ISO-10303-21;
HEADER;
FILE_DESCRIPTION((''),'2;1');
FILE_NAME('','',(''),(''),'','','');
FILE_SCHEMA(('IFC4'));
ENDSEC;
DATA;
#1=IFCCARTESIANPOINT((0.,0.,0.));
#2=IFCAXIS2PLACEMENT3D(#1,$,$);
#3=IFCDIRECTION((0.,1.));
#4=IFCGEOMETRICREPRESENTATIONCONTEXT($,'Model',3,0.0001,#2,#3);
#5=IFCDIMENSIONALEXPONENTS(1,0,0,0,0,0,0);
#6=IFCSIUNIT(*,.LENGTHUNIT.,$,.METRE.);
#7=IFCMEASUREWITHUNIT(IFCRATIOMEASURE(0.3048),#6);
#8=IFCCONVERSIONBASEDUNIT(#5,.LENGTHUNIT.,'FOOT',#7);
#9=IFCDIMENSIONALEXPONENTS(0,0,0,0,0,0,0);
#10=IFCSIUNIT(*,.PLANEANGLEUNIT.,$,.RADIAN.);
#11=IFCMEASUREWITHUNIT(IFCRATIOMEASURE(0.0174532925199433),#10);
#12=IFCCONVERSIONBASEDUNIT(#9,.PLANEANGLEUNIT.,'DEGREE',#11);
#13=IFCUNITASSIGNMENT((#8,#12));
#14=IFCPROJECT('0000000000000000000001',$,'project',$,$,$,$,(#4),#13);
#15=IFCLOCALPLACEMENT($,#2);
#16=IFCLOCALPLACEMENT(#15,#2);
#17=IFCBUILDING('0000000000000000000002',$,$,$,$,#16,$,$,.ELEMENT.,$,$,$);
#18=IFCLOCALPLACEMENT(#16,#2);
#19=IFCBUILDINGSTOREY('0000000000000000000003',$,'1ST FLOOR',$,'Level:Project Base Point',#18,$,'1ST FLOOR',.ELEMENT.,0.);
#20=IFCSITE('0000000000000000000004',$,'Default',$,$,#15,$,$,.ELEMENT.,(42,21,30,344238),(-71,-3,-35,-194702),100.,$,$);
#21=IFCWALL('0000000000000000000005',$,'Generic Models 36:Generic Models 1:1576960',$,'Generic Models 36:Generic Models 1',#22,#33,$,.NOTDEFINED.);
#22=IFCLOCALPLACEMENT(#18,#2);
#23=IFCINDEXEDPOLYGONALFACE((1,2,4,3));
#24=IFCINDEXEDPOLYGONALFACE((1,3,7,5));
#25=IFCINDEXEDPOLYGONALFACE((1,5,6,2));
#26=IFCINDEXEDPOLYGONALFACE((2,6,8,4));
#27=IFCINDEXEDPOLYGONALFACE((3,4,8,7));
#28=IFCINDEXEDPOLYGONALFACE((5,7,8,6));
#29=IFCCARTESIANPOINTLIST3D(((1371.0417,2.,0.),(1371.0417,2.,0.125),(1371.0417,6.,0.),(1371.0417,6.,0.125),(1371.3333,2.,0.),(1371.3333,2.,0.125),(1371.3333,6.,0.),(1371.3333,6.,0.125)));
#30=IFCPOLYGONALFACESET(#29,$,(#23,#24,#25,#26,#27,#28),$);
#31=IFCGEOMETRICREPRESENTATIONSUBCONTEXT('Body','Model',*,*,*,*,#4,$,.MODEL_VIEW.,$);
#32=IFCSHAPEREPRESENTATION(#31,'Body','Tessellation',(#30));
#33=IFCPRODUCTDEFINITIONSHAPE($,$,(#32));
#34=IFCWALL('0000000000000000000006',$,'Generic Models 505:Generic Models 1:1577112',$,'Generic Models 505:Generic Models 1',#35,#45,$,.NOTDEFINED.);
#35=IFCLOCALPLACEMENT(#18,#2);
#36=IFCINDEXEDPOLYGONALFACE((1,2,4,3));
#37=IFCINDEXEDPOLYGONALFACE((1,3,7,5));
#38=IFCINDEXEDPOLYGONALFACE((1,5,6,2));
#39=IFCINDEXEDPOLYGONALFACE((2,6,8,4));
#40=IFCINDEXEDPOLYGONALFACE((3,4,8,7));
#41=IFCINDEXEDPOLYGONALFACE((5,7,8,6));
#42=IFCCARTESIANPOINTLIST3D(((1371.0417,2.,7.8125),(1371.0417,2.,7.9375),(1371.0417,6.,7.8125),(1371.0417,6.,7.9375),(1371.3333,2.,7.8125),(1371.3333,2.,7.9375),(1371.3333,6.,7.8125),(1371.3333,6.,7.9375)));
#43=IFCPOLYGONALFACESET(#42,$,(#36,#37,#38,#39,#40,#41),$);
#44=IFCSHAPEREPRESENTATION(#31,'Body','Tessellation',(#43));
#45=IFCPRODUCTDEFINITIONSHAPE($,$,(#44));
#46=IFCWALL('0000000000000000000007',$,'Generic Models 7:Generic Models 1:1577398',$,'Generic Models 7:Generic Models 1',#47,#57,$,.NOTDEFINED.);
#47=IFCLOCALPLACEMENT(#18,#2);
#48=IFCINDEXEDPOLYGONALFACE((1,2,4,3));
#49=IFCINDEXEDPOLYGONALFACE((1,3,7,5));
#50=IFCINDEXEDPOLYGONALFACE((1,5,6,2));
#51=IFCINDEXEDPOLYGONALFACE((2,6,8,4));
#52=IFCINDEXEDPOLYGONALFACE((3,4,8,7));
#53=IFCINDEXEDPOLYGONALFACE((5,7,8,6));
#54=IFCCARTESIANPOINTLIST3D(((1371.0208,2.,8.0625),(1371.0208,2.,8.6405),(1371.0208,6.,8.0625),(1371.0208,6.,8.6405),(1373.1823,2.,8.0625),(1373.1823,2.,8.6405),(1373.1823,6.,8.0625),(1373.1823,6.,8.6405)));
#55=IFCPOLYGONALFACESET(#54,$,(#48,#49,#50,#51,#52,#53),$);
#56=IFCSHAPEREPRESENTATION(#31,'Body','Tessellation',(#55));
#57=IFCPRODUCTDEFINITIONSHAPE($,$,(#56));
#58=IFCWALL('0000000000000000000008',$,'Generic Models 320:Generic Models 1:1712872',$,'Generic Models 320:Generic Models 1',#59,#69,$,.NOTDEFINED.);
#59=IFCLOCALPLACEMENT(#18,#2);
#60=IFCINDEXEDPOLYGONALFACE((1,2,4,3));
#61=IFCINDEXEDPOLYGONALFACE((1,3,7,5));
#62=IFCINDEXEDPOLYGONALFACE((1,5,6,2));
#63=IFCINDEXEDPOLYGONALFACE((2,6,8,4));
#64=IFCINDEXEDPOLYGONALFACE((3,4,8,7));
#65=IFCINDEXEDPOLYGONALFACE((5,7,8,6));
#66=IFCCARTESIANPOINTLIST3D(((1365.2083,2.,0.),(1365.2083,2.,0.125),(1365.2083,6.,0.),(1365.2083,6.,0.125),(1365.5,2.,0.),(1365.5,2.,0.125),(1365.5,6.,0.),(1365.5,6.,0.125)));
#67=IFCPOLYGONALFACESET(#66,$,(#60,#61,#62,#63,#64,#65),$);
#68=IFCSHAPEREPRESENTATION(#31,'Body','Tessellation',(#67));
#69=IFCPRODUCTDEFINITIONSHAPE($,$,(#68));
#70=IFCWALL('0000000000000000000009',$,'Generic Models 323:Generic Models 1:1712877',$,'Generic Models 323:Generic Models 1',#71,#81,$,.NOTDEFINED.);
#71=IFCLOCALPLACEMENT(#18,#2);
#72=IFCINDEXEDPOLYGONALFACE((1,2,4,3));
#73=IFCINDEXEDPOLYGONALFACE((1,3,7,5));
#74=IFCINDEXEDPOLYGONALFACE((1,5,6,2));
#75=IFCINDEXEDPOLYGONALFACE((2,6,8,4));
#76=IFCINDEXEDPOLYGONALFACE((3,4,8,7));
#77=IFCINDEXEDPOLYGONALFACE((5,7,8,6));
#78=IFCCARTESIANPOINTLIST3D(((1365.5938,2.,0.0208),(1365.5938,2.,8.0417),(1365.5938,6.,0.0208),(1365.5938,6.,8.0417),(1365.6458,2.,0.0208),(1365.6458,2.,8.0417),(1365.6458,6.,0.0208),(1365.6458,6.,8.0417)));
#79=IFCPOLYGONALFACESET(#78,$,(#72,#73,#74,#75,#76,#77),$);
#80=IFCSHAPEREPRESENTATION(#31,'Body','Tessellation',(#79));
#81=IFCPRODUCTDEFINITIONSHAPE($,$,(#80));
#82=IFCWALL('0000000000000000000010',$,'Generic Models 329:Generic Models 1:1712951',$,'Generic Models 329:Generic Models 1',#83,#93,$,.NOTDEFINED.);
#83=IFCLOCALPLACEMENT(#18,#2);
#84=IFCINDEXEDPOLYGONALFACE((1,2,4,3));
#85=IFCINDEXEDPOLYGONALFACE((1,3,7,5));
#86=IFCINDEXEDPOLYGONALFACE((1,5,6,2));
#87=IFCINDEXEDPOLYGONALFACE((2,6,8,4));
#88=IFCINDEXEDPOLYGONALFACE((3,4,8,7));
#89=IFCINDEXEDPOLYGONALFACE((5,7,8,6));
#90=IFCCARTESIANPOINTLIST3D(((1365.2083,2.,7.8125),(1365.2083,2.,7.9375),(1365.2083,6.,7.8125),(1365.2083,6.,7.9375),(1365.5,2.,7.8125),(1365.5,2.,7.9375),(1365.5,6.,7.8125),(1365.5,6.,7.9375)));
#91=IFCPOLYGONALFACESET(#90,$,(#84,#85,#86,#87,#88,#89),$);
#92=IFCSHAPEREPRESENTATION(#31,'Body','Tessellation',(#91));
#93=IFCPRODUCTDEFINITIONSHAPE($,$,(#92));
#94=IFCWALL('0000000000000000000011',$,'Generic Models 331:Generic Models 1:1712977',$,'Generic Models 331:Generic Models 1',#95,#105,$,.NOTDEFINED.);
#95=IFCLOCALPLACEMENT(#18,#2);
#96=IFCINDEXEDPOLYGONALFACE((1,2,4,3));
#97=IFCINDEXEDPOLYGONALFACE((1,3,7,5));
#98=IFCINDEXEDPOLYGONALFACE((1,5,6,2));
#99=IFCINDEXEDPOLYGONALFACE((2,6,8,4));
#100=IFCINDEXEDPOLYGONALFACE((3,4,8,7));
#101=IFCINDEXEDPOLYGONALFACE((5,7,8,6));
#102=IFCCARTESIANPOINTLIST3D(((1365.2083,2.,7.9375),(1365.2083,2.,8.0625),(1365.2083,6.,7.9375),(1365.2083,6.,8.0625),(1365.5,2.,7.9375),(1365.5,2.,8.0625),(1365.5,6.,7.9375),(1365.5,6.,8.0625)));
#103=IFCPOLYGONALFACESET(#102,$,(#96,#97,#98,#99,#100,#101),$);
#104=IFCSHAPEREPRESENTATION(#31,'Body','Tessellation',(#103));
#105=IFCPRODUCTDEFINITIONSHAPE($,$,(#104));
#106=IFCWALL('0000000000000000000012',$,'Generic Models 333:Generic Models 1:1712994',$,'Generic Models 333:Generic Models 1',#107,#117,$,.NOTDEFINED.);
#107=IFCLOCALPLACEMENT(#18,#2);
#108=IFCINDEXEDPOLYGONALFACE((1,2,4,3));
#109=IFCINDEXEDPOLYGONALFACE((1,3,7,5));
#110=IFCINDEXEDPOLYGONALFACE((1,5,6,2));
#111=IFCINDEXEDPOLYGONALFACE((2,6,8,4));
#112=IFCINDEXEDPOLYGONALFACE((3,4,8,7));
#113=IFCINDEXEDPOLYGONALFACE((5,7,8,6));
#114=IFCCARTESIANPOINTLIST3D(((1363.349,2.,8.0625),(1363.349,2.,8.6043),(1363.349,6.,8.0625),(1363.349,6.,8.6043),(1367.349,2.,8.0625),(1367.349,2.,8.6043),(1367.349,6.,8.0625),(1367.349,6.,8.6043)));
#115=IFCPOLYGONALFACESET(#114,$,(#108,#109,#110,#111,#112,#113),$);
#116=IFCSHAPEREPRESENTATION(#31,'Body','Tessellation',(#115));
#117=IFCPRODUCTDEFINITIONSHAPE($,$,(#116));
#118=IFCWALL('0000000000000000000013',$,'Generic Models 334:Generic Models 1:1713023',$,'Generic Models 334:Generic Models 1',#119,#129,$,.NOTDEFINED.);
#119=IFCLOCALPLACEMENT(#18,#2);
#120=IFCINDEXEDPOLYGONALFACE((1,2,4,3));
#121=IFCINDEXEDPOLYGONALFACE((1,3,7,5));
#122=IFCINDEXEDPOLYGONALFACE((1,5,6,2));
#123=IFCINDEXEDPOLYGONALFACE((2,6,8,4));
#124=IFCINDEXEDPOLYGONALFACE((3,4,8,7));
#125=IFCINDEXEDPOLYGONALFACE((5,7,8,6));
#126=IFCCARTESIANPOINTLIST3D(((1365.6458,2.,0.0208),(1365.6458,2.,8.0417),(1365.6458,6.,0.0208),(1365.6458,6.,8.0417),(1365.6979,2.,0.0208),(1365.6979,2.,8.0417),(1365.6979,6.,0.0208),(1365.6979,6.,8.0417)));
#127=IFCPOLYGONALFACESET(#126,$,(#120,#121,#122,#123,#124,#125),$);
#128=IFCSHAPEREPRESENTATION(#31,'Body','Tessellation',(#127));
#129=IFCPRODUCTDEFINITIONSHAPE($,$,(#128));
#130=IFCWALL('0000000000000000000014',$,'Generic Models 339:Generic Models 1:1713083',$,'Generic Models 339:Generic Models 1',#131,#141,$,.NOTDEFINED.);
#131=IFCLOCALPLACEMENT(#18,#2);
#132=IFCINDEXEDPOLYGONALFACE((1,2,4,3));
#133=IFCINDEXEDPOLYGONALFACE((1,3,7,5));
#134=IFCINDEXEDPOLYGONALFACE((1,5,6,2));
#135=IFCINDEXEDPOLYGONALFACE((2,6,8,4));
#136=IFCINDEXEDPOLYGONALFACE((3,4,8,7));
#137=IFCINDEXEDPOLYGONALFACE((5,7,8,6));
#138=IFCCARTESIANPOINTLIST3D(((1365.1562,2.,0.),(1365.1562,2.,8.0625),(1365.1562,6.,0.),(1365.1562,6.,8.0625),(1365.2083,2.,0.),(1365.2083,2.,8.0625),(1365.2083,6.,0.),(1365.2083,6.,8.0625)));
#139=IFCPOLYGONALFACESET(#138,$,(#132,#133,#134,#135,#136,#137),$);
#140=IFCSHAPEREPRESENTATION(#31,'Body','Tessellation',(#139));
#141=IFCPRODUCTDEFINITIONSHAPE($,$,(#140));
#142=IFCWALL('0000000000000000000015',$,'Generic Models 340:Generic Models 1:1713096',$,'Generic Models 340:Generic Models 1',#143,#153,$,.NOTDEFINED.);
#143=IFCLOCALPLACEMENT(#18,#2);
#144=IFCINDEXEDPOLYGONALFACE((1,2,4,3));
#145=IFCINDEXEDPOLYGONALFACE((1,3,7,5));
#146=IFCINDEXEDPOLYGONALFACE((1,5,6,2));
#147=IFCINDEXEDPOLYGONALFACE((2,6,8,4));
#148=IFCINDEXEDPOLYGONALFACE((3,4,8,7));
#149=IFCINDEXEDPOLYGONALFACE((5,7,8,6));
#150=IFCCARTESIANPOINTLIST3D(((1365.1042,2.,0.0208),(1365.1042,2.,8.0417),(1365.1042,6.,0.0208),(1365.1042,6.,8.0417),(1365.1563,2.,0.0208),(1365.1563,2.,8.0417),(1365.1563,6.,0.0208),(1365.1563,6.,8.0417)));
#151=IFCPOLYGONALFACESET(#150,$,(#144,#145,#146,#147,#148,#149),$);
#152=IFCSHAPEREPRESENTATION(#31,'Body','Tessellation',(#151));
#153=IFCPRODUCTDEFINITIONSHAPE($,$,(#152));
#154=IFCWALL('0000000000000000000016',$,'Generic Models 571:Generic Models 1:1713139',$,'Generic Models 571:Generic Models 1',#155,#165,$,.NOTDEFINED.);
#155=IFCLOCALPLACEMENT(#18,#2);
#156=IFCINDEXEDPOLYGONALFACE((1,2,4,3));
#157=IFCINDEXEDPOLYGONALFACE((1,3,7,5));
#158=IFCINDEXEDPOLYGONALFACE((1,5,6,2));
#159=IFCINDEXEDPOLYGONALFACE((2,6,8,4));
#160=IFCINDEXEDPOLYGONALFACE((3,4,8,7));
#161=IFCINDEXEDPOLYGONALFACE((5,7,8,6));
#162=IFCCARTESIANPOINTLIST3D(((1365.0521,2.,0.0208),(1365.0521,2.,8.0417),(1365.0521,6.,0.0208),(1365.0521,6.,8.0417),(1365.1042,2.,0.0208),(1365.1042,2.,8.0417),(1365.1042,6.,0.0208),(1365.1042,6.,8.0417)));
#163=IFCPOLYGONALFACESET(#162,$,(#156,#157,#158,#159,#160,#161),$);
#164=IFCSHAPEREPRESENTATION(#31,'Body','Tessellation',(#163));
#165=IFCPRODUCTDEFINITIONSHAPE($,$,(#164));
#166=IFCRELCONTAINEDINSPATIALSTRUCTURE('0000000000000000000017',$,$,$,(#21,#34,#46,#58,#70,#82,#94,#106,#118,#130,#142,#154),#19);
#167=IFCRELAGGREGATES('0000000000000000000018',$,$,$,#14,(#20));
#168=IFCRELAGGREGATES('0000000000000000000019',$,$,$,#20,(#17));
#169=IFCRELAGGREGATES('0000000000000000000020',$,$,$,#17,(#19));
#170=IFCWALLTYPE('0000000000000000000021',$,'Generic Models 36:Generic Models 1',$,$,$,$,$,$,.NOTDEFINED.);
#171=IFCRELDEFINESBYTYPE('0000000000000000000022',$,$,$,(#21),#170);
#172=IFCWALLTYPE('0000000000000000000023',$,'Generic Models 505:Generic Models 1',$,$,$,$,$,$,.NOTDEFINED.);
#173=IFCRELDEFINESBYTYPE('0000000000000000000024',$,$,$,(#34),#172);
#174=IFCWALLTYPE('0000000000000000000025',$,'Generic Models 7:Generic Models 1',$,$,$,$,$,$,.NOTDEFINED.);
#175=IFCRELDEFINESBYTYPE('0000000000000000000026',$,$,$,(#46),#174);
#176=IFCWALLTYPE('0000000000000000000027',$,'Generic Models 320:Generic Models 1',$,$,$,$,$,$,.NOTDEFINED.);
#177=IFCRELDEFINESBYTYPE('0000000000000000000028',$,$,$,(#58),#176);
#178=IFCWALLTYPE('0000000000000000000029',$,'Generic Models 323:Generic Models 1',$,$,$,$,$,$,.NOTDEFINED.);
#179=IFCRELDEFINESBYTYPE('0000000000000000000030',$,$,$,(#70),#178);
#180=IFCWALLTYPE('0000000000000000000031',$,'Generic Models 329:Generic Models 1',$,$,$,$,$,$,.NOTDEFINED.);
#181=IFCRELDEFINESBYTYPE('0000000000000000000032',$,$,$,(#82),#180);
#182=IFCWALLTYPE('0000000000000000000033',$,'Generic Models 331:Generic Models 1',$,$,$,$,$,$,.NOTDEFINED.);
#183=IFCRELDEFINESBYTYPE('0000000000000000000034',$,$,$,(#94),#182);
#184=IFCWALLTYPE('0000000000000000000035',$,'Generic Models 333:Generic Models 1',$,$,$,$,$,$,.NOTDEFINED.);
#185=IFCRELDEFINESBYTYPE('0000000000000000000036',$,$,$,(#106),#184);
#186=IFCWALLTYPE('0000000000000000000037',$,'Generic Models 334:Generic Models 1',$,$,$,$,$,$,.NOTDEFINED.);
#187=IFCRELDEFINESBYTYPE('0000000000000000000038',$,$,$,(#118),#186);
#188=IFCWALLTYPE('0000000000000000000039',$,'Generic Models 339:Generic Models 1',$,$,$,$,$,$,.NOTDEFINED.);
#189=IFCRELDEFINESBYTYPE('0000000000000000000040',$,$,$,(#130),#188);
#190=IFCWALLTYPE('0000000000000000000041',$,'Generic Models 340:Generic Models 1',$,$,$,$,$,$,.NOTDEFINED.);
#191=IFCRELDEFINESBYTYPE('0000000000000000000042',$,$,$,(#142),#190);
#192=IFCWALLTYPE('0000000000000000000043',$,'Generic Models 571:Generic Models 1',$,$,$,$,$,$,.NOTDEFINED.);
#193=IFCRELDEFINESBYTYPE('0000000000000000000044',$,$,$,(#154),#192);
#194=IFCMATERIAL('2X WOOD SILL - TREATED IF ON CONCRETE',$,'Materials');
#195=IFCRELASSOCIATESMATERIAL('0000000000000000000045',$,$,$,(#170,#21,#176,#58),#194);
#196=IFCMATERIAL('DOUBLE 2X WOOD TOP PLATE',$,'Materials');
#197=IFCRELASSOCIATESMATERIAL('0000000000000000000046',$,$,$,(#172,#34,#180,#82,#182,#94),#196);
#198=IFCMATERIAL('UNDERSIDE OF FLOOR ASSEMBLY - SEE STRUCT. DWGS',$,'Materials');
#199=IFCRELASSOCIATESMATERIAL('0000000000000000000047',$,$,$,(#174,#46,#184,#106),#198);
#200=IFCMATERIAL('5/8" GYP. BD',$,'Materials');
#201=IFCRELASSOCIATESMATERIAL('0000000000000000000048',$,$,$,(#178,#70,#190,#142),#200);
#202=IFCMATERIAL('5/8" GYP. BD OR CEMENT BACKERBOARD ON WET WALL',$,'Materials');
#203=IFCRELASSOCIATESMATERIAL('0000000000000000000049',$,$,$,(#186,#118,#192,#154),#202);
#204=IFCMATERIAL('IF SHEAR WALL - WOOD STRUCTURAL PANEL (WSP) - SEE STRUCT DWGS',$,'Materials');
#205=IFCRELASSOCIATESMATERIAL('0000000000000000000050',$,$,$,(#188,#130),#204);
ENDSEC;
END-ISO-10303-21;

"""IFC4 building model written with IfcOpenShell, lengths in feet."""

from ifc_helpers import new_model, entity, si_unit, converted_unit, direction, frame, frame_2d, origin, origin_2d_with_axis, place, context, subcontext, project, spatial, rectangle, extrude, material, type_object, element, save


model = new_model("IFC4")

# Units and contexts
model_context = context("Model", 3, precision=0.0001, world=origin(), true_north=direction((0.0, 1.0)))
body_context = subcontext(model_context, "Body", "Model", "MODEL_VIEW")
ifc_project = project(units=[converted_unit("LENGTHUNIT", "FOOT", entity("IfcRatioMeasure", 0.3048), si_unit("LENGTHUNIT", "METRE"), dimensions=[1, 0, 0, 0, 0, 0, 0]), converted_unit("PLANEANGLEUNIT", "DEGREE", entity("IfcRatioMeasure", 0.0174532925199433), si_unit("PLANEANGLEUNIT", "RADIAN"), dimensions=[0, 0, 0, 0, 0, 0, 0])], contexts=[model_context])

# Site, building, storey
site_placement = place(None, origin())
site = spatial("IfcSite", under=ifc_project, at=site_placement, Name="Default", CompositionType="ELEMENT", RefLatitude=(42, 21, 30, 344238), RefLongitude=(-71, -3, -35, -194702), RefElevation=100.0)
building_placement = place(site_placement, origin())
building = spatial("IfcBuilding", under=site, at=building_placement, CompositionType="ELEMENT")
storey_placement = place(building_placement, origin())
storey = spatial("IfcBuildingStorey", under=building, at=storey_placement, Name="1ST FLOOR", ObjectType="Level:Project Base Point", LongName="1ST FLOOR", CompositionType="ELEMENT", Elevation=0.0)

# Walls
ifc_material_1 = material(Name="2X WOOD SILL - TREATED IF ON CONCRETE", Category="Materials")
wall_type_1 = type_object("IfcWallType", Name="Generic Models 36:Generic Models 1", PredefinedType="NOTDEFINED", material=ifc_material_1)
wall_1_placement = place(storey_placement, frame((1371.0417, 2.0, 0.0), z_axis=(0.0, 0.0, 1.0), x_axis=(0.0, 1.0, 0.0)))
element("IfcWall", 1, at=wall_1_placement, inside=storey, type_object=wall_type_1, material=ifc_material_1, Name="Generic Models 36:Generic Models 1:1576960", ObjectType="Generic Models 36:Generic Models 1", PredefinedType="NOTDEFINED", context=body_context, shape_type="SweptSolid", body=[
    extrude(rectangle(XDim=4.0, YDim=0.2917, at=frame_2d((0.0, 0.0), x_axis=(1.0, 0.0))), frame((2.0, -0.1458, 0.0)), (0.0, 0.0, 1.0), 0.125),
])
ifc_material_2 = material(Name="DOUBLE 2X WOOD TOP PLATE", Category="Materials")
wall_type_2 = type_object("IfcWallType", Name="Generic Models 505:Generic Models 1", PredefinedType="NOTDEFINED", material=ifc_material_2)
wall_2_placement = place(storey_placement, frame((1371.0417, 2.0, 7.8125), z_axis=(0.0, 0.0, 1.0), x_axis=(0.0, 1.0, 0.0)))
element("IfcWall", 2, at=wall_2_placement, inside=storey, type_object=wall_type_2, material=ifc_material_2, Name="Generic Models 505:Generic Models 1:1577112", ObjectType="Generic Models 505:Generic Models 1", PredefinedType="NOTDEFINED", context=body_context, shape_type="SweptSolid", body=[
    extrude(rectangle(XDim=4.0, YDim=0.2917, at=frame_2d((0.0, 0.0), x_axis=(1.0, 0.0))), frame((2.0, -0.1458, 0.0)), (0.0, 0.0, 1.0), 0.125),
])
ifc_material_3 = material(Name="UNDERSIDE OF FLOOR ASSEMBLY - SEE STRUCT. DWGS", Category="Materials")
wall_type_3 = type_object("IfcWallType", Name="Generic Models 7:Generic Models 1", PredefinedType="NOTDEFINED", material=ifc_material_3)
wall_3_placement = place(storey_placement, frame((1371.0208, 2.0, 8.0625), z_axis=(0.0, 0.0, 1.0), x_axis=(0.0, 1.0, 0.0)))
element("IfcWall", 3, at=wall_3_placement, inside=storey, type_object=wall_type_3, material=ifc_material_3, Name="Generic Models 7:Generic Models 1:1577398", ObjectType="Generic Models 7:Generic Models 1", PredefinedType="NOTDEFINED", context=body_context, shape_type="SweptSolid", body=[
    extrude(rectangle(XDim=4.0, YDim=2.1615, at=frame_2d((0.0, 0.0), x_axis=(1.0, 0.0))), frame((2.0, -1.0807, 0.0)), (0.0, 0.0, 1.0), 0.578),
])
wall_type_4 = type_object("IfcWallType", Name="Generic Models 320:Generic Models 1", PredefinedType="NOTDEFINED", material=ifc_material_1)
wall_4_placement = place(storey_placement, frame((1365.2083, 2.0, 0.0), z_axis=(0.0, 0.0, 1.0), x_axis=(0.0, 1.0, 0.0)))
element("IfcWall", 4, at=wall_4_placement, inside=storey, type_object=wall_type_4, material=ifc_material_1, Name="Generic Models 320:Generic Models 1:1712872", ObjectType="Generic Models 320:Generic Models 1", PredefinedType="NOTDEFINED", context=body_context, shape_type="SweptSolid", body=[
    extrude(rectangle(XDim=4.0, YDim=0.2917, at=frame_2d((0.0, 0.0), x_axis=(1.0, 0.0))), frame((2.0, -0.1458, 0.0)), (0.0, 0.0, 1.0), 0.125),
])
ifc_material_4 = material(Name="5/8\" GYP. BD", Category="Materials")
wall_type_5 = type_object("IfcWallType", Name="Generic Models 323:Generic Models 1", PredefinedType="NOTDEFINED", material=ifc_material_4)
wall_5_placement = place(storey_placement, frame((1365.5938, 2.0, 0.0208), z_axis=(0.0, 0.0, 1.0), x_axis=(0.0, 1.0, 0.0)))
element("IfcWall", 5, at=wall_5_placement, inside=storey, type_object=wall_type_5, material=ifc_material_4, Name="Generic Models 323:Generic Models 1:1712877", ObjectType="Generic Models 323:Generic Models 1", PredefinedType="NOTDEFINED", context=body_context, shape_type="SweptSolid", body=[
    extrude(rectangle(XDim=4.0, YDim=0.0521, at=origin_2d_with_axis()), frame((2.0, -0.026, 0.0)), (0.0, 0.0, 1.0), 8.0208),
])
wall_type_6 = type_object("IfcWallType", Name="Generic Models 329:Generic Models 1", PredefinedType="NOTDEFINED", material=ifc_material_2)
wall_6_placement = place(storey_placement, frame((1365.2083, 2.0, 7.8125), z_axis=(0.0, 0.0, 1.0), x_axis=(0.0, 1.0, 0.0)))
element("IfcWall", 6, at=wall_6_placement, inside=storey, type_object=wall_type_6, material=ifc_material_2, Name="Generic Models 329:Generic Models 1:1712951", ObjectType="Generic Models 329:Generic Models 1", PredefinedType="NOTDEFINED", context=body_context, shape_type="SweptSolid", body=[
    extrude(rectangle(XDim=4.0, YDim=0.2917, at=frame_2d((0.0, 0.0), x_axis=(1.0, 0.0))), frame((2.0, -0.1458, 0.0)), (0.0, 0.0, 1.0), 0.125),
])
wall_type_7 = type_object("IfcWallType", Name="Generic Models 331:Generic Models 1", PredefinedType="NOTDEFINED", material=ifc_material_2)
wall_7_placement = place(storey_placement, frame((1365.2083, 2.0, 7.9375), z_axis=(0.0, 0.0, 1.0), x_axis=(0.0, 1.0, 0.0)))
element("IfcWall", 7, at=wall_7_placement, inside=storey, type_object=wall_type_7, material=ifc_material_2, Name="Generic Models 331:Generic Models 1:1712977", ObjectType="Generic Models 331:Generic Models 1", PredefinedType="NOTDEFINED", context=body_context, shape_type="SweptSolid", body=[
    extrude(rectangle(XDim=4.0, YDim=0.2917, at=frame_2d((0.0, 0.0), x_axis=(1.0, 0.0))), frame((2.0, -0.1458, 0.0)), (0.0, 0.0, 1.0), 0.125),
])
wall_type_8 = type_object("IfcWallType", Name="Generic Models 333:Generic Models 1", PredefinedType="NOTDEFINED", material=ifc_material_3)
wall_8_placement = place(storey_placement, frame((1363.349, 2.0, 8.0625), z_axis=(0.0, 0.0, 1.0), x_axis=(0.0, 1.0, 0.0)))
element("IfcWall", 8, at=wall_8_placement, inside=storey, type_object=wall_type_8, material=ifc_material_3, Name="Generic Models 333:Generic Models 1:1712994", ObjectType="Generic Models 333:Generic Models 1", PredefinedType="NOTDEFINED", context=body_context, shape_type="SweptSolid", body=[
    extrude(rectangle(XDim=4.0, YDim=4.0, at=origin_2d_with_axis()), frame((2.0, -2.0, 0.0)), (0.0, 0.0, 1.0), 0.5418),
])
ifc_material_5 = material(Name="5/8\" GYP. BD OR CEMENT BACKERBOARD ON WET WALL", Category="Materials")
wall_type_9 = type_object("IfcWallType", Name="Generic Models 334:Generic Models 1", PredefinedType="NOTDEFINED", material=ifc_material_5)
wall_9_placement = place(storey_placement, frame((1365.6458, 2.0, 0.0208), z_axis=(0.0, 0.0, 1.0), x_axis=(0.0, 1.0, 0.0)))
element("IfcWall", 9, at=wall_9_placement, inside=storey, type_object=wall_type_9, material=ifc_material_5, Name="Generic Models 334:Generic Models 1:1713023", ObjectType="Generic Models 334:Generic Models 1", PredefinedType="NOTDEFINED", context=body_context, shape_type="SweptSolid", body=[
    extrude(rectangle(XDim=4.0, YDim=0.0521, at=frame_2d((0.0, 0.0), x_axis=(1.0, 0.0))), frame((2.0, -0.026, 0.0)), (0.0, 0.0, 1.0), 8.0208),
])
ifc_material_6 = material(Name="IF SHEAR WALL - WOOD STRUCTURAL PANEL (WSP) - SEE STRUCT DWGS", Category="Materials")
wall_type_10 = type_object("IfcWallType", Name="Generic Models 339:Generic Models 1", PredefinedType="NOTDEFINED", material=ifc_material_6)
wall_10_placement = place(storey_placement, frame((1365.1562, 2.0, 0.0), z_axis=(0.0, 0.0, 1.0), x_axis=(0.0, 1.0, 0.0)))
element("IfcWall", 10, at=wall_10_placement, inside=storey, type_object=wall_type_10, material=ifc_material_6, Name="Generic Models 339:Generic Models 1:1713083", ObjectType="Generic Models 339:Generic Models 1", PredefinedType="NOTDEFINED", context=body_context, shape_type="SweptSolid", body=[
    extrude(rectangle(XDim=4.0, YDim=0.0521, at=origin_2d_with_axis()), frame((2.0, -0.026, 0.0)), (0.0, 0.0, 1.0), 8.0625),
])
wall_type_11 = type_object("IfcWallType", Name="Generic Models 340:Generic Models 1", PredefinedType="NOTDEFINED", material=ifc_material_4)
wall_11_placement = place(storey_placement, frame((1365.1042, 2.0, 0.0208), z_axis=(0.0, 0.0, 1.0), x_axis=(0.0, 1.0, 0.0)))
element("IfcWall", 11, at=wall_11_placement, inside=storey, type_object=wall_type_11, material=ifc_material_4, Name="Generic Models 340:Generic Models 1:1713096", ObjectType="Generic Models 340:Generic Models 1", PredefinedType="NOTDEFINED", context=body_context, shape_type="SweptSolid", body=[
    extrude(rectangle(XDim=4.0, YDim=0.0521, at=frame_2d((0.0, 0.0), x_axis=(1.0, 0.0))), frame((2.0, -0.026, 0.0)), (0.0, 0.0, 1.0), 8.0208),
])
wall_type_12 = type_object("IfcWallType", Name="Generic Models 571:Generic Models 1", PredefinedType="NOTDEFINED", material=ifc_material_5)
wall_12_placement = place(storey_placement, frame((1365.0521, 2.0, 0.0208), z_axis=(0.0, 0.0, 1.0), x_axis=(0.0, 1.0, 0.0)))
element("IfcWall", 12, at=wall_12_placement, inside=storey, type_object=wall_type_12, material=ifc_material_5, Name="Generic Models 571:Generic Models 1:1713139", ObjectType="Generic Models 571:Generic Models 1", PredefinedType="NOTDEFINED", context=body_context, shape_type="SweptSolid", body=[
    extrude(rectangle(XDim=4.0, YDim=0.0521, at=origin_2d_with_axis()), frame((2.0, -0.026, 0.0)), (0.0, 0.0, 1.0), 8.0208),
])

save(model, "model.ifc")
